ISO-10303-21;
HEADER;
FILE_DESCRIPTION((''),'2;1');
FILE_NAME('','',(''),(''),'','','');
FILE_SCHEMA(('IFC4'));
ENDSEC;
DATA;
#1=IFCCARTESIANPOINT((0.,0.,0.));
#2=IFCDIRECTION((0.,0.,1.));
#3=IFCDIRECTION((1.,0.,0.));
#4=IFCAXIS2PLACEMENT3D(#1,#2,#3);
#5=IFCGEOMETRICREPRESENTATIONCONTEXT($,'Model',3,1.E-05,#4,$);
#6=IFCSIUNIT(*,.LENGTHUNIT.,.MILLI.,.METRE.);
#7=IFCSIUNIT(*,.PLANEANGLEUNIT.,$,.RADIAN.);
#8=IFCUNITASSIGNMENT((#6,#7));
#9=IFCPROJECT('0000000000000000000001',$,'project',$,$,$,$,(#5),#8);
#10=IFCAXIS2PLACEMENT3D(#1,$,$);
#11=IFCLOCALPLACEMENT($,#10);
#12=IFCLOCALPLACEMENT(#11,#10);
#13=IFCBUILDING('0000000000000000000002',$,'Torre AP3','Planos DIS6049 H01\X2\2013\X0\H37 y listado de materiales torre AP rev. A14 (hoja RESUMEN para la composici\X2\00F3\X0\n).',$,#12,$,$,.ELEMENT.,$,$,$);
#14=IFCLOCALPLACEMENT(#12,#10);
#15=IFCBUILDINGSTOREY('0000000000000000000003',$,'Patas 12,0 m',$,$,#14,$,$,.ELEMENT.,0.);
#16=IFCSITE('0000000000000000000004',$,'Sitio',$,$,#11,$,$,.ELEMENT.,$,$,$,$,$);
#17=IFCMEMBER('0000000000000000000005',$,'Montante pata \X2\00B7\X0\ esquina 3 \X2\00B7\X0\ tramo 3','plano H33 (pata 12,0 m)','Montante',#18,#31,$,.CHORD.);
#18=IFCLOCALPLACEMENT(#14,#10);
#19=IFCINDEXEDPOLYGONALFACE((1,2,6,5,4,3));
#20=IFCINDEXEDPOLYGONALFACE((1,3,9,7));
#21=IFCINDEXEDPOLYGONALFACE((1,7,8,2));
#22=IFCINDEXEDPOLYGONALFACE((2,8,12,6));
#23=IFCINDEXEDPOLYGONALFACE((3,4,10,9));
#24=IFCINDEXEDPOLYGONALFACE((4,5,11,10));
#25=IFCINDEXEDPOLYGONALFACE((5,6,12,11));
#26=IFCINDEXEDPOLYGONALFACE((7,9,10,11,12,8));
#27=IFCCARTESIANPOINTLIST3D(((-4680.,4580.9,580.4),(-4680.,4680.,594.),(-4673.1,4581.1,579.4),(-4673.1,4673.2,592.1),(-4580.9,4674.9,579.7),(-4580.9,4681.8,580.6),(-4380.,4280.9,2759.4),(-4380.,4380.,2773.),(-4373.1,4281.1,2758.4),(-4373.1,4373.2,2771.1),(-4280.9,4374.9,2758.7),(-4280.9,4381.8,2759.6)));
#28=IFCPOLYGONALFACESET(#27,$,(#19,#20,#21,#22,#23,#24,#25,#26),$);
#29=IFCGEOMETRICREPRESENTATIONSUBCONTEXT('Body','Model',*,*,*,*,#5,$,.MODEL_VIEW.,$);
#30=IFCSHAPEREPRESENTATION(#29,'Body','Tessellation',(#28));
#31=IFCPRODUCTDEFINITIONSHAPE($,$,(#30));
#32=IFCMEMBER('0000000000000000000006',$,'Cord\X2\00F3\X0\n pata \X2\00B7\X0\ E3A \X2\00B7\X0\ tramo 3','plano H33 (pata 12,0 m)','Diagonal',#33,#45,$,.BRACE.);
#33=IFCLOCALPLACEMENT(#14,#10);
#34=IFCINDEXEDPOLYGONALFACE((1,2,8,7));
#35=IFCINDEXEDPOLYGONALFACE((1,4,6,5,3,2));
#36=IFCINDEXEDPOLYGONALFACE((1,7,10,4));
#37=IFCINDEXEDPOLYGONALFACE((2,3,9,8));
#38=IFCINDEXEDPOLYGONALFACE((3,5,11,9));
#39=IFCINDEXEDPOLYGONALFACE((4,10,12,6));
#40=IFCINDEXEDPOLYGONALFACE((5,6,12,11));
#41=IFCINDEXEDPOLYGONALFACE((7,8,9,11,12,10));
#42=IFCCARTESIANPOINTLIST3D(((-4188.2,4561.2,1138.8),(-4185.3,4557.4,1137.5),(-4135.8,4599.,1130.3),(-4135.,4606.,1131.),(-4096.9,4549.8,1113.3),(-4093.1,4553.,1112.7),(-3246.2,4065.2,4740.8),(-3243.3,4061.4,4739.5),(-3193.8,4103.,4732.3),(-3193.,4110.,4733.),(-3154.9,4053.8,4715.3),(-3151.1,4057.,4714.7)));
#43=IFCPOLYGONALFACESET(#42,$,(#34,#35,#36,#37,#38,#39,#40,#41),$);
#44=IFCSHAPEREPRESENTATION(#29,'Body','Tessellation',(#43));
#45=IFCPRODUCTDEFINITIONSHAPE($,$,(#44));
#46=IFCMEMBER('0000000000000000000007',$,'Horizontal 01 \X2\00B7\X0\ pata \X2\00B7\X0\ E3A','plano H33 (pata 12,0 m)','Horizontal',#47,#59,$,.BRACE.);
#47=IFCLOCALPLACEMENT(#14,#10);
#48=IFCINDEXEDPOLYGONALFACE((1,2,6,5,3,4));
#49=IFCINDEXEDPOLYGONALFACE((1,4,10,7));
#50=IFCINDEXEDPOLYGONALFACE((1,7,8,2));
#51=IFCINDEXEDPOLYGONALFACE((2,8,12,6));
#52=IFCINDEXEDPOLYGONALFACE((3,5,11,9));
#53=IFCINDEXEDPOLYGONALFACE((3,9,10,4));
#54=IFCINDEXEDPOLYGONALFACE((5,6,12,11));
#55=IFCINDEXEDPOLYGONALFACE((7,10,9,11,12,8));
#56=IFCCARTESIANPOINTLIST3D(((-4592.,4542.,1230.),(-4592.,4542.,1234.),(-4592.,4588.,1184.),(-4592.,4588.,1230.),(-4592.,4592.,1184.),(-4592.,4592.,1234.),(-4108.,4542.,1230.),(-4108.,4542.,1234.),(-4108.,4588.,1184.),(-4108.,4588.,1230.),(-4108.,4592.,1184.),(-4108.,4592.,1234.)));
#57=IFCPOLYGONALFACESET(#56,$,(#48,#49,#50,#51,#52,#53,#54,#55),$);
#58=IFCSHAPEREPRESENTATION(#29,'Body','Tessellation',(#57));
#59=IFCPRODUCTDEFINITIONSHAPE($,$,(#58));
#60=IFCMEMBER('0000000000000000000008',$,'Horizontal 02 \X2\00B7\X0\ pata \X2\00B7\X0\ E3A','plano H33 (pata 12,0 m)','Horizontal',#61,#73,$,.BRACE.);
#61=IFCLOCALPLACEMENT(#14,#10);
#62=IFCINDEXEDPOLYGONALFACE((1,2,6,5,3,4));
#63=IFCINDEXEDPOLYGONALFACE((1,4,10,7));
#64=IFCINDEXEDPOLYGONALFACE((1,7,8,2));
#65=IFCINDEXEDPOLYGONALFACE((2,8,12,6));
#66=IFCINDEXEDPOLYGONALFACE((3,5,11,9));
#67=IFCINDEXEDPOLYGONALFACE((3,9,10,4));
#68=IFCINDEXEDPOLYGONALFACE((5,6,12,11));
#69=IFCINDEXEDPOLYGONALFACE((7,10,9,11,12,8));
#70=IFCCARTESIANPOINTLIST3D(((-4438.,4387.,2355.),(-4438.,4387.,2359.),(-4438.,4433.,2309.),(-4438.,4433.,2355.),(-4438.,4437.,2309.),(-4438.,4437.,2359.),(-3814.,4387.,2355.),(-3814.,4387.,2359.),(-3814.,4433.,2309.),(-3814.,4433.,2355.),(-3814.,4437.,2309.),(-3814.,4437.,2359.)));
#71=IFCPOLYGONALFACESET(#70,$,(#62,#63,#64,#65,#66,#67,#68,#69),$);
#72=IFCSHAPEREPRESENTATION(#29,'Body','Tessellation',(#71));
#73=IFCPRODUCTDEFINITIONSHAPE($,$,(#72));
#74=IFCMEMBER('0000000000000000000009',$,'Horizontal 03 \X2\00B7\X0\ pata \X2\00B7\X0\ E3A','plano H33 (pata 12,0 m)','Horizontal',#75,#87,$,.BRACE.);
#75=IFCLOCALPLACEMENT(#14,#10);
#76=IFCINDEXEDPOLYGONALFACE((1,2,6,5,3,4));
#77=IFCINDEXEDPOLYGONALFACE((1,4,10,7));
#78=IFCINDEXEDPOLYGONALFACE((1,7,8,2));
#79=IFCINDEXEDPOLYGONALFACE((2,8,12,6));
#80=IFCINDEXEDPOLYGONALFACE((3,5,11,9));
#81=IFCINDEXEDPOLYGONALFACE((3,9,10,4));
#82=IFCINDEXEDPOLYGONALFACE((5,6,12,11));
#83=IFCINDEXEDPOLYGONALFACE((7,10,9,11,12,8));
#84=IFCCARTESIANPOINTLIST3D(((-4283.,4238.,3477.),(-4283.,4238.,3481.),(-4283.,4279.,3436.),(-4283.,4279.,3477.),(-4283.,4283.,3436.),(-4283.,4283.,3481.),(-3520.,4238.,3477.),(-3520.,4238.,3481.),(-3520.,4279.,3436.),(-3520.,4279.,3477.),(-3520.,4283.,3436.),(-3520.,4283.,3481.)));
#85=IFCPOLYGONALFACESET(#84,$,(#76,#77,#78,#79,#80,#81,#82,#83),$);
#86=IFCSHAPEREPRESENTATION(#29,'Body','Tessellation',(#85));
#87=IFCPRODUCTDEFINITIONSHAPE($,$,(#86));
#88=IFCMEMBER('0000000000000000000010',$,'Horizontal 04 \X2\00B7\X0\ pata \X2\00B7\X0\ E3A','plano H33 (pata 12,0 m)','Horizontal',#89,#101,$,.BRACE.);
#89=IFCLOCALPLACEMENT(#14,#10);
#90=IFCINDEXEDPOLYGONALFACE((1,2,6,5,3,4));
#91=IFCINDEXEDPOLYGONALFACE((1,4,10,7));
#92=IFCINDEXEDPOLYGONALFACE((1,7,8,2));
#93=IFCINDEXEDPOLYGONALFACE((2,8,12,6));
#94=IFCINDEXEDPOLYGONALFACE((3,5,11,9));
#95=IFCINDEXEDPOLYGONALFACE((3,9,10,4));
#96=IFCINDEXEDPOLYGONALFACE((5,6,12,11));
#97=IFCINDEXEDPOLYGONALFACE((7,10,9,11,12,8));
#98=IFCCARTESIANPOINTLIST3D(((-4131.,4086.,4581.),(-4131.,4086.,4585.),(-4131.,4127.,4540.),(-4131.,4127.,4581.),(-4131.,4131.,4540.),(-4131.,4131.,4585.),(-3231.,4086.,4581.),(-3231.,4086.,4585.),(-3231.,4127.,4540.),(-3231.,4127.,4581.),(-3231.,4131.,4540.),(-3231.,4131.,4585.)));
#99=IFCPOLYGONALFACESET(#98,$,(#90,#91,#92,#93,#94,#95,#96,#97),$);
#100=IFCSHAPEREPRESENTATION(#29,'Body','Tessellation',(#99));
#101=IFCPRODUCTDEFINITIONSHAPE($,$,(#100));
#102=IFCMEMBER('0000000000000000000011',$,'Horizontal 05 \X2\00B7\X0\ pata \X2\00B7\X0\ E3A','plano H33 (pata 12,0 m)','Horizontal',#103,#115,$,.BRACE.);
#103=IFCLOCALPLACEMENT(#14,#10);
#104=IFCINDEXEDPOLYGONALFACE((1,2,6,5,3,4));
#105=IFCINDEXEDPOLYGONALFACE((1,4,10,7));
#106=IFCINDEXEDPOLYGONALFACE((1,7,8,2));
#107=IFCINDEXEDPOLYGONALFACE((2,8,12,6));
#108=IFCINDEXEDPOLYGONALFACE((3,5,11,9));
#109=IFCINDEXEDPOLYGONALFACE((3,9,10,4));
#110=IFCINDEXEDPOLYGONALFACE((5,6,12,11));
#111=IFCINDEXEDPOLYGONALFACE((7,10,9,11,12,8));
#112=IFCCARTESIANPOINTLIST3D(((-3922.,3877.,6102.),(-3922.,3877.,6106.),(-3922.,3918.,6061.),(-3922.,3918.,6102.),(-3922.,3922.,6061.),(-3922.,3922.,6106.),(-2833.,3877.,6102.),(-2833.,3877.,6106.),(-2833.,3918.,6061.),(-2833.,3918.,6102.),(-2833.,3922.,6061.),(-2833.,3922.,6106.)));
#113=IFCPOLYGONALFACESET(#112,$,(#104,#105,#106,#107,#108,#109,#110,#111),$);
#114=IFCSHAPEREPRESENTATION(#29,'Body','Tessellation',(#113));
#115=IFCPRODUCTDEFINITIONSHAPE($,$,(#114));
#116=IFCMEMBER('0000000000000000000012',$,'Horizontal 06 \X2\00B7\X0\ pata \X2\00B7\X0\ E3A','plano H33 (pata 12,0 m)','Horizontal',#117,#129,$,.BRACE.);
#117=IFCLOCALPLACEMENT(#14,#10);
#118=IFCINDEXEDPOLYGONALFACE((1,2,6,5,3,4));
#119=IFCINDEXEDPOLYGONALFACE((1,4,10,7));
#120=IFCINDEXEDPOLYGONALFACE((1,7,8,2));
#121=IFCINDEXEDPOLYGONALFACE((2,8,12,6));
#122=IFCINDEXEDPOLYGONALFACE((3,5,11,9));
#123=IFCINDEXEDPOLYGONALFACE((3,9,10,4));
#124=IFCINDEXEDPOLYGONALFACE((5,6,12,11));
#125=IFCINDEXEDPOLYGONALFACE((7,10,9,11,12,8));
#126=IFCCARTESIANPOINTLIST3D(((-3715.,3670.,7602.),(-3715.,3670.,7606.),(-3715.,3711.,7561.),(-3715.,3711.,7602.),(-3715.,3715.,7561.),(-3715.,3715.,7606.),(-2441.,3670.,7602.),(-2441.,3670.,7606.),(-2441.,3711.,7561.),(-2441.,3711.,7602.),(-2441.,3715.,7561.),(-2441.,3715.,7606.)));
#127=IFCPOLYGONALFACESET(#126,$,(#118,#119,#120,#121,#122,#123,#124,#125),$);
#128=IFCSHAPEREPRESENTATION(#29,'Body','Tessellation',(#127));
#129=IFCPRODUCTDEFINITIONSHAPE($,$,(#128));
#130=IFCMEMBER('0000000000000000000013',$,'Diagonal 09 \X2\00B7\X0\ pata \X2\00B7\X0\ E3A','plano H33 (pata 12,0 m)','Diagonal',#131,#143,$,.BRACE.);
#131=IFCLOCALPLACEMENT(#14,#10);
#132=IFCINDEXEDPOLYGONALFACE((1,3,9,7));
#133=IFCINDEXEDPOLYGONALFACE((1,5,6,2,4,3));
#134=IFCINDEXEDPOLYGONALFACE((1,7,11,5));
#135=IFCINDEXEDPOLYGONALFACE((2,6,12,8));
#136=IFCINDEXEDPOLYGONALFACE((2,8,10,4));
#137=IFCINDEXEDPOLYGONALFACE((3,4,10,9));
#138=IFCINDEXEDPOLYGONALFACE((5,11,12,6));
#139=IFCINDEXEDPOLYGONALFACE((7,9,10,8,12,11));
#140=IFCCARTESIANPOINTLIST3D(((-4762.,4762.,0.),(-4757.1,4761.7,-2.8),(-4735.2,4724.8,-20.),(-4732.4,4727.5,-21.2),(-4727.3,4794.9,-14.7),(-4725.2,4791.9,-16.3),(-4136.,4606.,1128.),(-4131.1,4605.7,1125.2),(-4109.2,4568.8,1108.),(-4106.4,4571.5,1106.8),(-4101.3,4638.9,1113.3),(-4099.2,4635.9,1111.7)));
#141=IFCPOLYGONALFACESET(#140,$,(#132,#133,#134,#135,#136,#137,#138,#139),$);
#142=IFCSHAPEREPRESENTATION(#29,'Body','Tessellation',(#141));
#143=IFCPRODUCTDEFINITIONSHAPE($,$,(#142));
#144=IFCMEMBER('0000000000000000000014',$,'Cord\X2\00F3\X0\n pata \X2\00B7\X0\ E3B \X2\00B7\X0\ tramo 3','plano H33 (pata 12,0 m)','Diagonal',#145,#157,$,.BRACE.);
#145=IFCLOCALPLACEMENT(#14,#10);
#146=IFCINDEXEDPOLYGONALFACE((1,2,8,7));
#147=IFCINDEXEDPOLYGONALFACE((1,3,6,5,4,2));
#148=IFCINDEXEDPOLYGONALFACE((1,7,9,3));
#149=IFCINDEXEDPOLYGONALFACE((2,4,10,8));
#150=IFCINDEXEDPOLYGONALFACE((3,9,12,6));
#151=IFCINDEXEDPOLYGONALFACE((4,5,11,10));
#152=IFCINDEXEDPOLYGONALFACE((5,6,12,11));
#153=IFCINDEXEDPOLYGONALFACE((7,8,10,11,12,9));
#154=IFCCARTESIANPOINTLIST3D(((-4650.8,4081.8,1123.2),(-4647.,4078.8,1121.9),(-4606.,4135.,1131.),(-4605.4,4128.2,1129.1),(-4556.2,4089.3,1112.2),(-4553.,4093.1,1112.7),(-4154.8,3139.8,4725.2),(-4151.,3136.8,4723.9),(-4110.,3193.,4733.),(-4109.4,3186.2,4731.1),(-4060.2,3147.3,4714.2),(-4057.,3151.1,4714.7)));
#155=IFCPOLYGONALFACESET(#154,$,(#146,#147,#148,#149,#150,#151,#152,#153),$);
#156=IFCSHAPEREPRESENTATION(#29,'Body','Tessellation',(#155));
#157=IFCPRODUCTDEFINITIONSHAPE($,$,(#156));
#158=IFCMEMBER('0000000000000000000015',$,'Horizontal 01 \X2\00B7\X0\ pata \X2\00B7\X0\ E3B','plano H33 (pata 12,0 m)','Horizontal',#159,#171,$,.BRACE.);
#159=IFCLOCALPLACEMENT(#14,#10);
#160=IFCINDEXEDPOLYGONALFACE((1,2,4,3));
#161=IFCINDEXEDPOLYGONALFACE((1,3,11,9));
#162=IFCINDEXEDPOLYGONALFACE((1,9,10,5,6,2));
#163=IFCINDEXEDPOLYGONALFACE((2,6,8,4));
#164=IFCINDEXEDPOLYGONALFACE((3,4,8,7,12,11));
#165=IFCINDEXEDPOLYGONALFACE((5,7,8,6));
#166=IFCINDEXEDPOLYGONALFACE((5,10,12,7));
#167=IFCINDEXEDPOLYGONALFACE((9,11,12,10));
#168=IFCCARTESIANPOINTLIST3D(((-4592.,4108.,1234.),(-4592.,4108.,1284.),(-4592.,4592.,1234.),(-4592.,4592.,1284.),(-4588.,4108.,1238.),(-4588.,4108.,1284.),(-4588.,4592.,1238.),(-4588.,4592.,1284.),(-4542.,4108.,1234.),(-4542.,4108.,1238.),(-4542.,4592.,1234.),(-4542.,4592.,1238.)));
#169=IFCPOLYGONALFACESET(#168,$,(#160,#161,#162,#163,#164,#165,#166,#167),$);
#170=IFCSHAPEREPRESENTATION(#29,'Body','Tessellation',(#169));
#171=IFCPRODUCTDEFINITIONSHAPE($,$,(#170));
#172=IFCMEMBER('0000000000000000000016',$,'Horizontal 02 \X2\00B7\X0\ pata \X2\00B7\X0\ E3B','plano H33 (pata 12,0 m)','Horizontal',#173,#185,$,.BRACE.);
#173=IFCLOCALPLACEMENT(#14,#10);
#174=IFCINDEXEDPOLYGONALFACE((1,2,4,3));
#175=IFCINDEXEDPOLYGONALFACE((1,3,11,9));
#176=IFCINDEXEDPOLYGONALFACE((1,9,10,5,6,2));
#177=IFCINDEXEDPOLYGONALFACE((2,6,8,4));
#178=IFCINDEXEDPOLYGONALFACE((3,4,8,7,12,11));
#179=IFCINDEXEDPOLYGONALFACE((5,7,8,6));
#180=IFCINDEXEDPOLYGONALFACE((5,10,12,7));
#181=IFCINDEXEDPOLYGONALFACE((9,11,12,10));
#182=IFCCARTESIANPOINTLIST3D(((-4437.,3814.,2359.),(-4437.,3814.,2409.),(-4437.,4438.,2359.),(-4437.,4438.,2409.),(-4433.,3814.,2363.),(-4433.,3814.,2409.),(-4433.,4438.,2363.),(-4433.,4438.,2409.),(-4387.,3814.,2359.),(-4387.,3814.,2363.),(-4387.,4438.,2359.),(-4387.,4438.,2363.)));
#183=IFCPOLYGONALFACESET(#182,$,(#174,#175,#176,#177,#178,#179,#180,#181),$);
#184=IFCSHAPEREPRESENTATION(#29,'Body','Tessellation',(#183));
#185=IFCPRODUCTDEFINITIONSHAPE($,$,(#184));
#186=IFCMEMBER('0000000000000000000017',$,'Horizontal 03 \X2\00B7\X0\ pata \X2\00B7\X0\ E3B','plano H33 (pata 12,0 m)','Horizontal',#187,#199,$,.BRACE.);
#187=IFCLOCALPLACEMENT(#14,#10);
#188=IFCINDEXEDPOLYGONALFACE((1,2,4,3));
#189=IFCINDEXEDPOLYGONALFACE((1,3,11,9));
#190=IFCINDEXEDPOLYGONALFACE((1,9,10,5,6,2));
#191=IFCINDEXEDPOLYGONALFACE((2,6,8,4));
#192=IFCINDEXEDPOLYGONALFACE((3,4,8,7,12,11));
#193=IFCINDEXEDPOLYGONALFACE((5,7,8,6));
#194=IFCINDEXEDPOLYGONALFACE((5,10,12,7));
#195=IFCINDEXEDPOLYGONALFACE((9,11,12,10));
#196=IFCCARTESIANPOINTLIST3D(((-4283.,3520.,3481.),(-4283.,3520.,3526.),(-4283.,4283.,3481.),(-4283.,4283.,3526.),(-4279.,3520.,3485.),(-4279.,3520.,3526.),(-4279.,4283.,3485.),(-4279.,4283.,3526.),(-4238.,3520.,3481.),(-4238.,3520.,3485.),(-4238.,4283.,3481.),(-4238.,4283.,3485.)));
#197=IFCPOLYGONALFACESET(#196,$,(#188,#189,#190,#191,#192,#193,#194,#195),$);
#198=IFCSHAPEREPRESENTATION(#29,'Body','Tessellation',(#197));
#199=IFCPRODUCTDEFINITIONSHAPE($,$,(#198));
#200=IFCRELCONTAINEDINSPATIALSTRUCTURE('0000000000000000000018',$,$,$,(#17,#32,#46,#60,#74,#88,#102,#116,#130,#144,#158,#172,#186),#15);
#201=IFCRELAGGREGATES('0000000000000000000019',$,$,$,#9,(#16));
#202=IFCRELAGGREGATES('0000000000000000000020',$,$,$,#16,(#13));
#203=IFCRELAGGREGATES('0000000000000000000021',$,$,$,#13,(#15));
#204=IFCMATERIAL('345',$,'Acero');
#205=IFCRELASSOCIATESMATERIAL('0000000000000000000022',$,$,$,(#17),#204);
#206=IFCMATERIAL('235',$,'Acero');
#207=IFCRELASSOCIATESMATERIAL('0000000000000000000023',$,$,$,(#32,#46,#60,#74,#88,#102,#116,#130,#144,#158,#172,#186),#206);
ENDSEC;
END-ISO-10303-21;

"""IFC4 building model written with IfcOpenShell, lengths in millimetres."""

from ifc_helpers import new_model, si_unit, frame, frame_2d, origin, origin_with_axes, place, context, subcontext, project, spatial, l_section, extrude, material, element, save


model = new_model("IFC4")

# Units and contexts
model_context = context("Model", 3, precision=1e-05, world=origin_with_axes())
body_context = subcontext(model_context, "Body", "Model", "MODEL_VIEW")
ifc_project = project(units=[si_unit("LENGTHUNIT", "METRE", prefix="MILLI"), si_unit("PLANEANGLEUNIT", "RADIAN")], contexts=[model_context])

# Site, building, storey
site_placement = place(None, origin())
site = spatial("IfcSite", under=ifc_project, at=site_placement, Name="Sitio", CompositionType="ELEMENT")
building_placement = place(site_placement, origin())
building = spatial("IfcBuilding", under=site, at=building_placement, Name="Torre AP3", Description="Planos DIS6049 H01–H37 y listado de materiales torre AP rev. A14 (hoja RESUMEN para la composición).", CompositionType="ELEMENT")
storey_placement = place(building_placement, origin())
storey = spatial("IfcBuildingStorey", under=building, at=storey_placement, Name="Patas 12,0 m", CompositionType="ELEMENT", Elevation=0.0)

# Members
ifc_material_1 = material(Name="345", Category="Acero")
member_1_placement = place(storey_placement, frame((-4380.0, 4380.0, 2773.0), z_axis=(-0.13514, 0.13514, -0.981567), x_axis=(0.990827, 0.018432, -0.133877)))
element("IfcMember", 1, at=member_1_placement, inside=storey, material=ifc_material_1, Name="Montante pata · esquina 3 · tramo 3", Description="plano H33 (pata 12,0 m)", ObjectType="Montante", PredefinedType="CHORD", context=body_context, shape_type="SweptSolid", body=[
    extrude(l_section(Depth=100.0, Width=100.0, Thickness=7.0, at=frame_2d((50.0, 50.0))), None, (0.0, 0.0, 1.0), 2219.9),
])
ifc_material_2 = material(Name="235", Category="Acero")
member_2_placement = place(storey_placement, frame((-3193.0, 4110.0, 4733.0), z_axis=(-0.250797, 0.132054, -0.958991), x_axis=(0.598693, -0.757312, -0.260854)))
element("IfcMember", 2, at=member_2_placement, inside=storey, material=ifc_material_2, Name="Cordón pata · E3A · tramo 3", Description="plano H33 (pata 12,0 m)", ObjectType="Diagonal", PredefinedType="BRACE", context=body_context, shape_type="SweptSolid", body=[
    extrude(l_section(Depth=70.0, Width=70.0, Thickness=5.0, at=frame_2d((35.0, 35.0))), None, (0.0, 0.0, 1.0), 3756.0),
])
member_3_placement = place(storey_placement, frame((-4592.0, 4592.0, 1234.0), z_axis=(1.0, 0.0, 0.0), x_axis=(0.0, -1.0, 0.0)))
element("IfcMember", 3, at=member_3_placement, inside=storey, material=ifc_material_2, Name="Horizontal 01 · pata · E3A", Description="plano H33 (pata 12,0 m)", ObjectType="Horizontal", PredefinedType="BRACE", context=body_context, shape_type="SweptSolid", body=[
    extrude(l_section(Depth=50.0, Width=50.0, Thickness=4.0, at=frame_2d((25.0, 25.0))), None, (0.0, 0.0, 1.0), 484.0),
])
member_4_placement = place(storey_placement, frame((-4438.0, 4437.0, 2359.0), z_axis=(1.0, 0.0, 0.0), x_axis=(0.0, -1.0, 0.0)))
element("IfcMember", 4, at=member_4_placement, inside=storey, material=ifc_material_2, Name="Horizontal 02 · pata · E3A", Description="plano H33 (pata 12,0 m)", ObjectType="Horizontal", PredefinedType="BRACE", context=body_context, shape_type="SweptSolid", body=[
    extrude(l_section(Depth=50.0, Width=50.0, Thickness=4.0, at=frame_2d((25.0, 25.0))), None, (0.0, 0.0, 1.0), 624.0),
])
member_5_placement = place(storey_placement, frame((-4283.0, 4283.0, 3481.0), z_axis=(1.0, 0.0, 0.0), x_axis=(0.0, -1.0, 0.0)))
element("IfcMember", 5, at=member_5_placement, inside=storey, material=ifc_material_2, Name="Horizontal 03 · pata · E3A", Description="plano H33 (pata 12,0 m)", ObjectType="Horizontal", PredefinedType="BRACE", context=body_context, shape_type="SweptSolid", body=[
    extrude(l_section(Depth=45.0, Width=45.0, Thickness=4.0, at=frame_2d((22.5, 22.5))), None, (0.0, 0.0, 1.0), 763.0),
])
member_6_placement = place(storey_placement, frame((-4131.0, 4131.0, 4585.0), z_axis=(1.0, 0.0, 0.0), x_axis=(0.0, -1.0, 0.0)))
element("IfcMember", 6, at=member_6_placement, inside=storey, material=ifc_material_2, Name="Horizontal 04 · pata · E3A", Description="plano H33 (pata 12,0 m)", ObjectType="Horizontal", PredefinedType="BRACE", context=body_context, shape_type="SweptSolid", body=[
    extrude(l_section(Depth=45.0, Width=45.0, Thickness=4.0, at=frame_2d((22.5, 22.5))), None, (0.0, 0.0, 1.0), 900.0),
])
member_7_placement = place(storey_placement, frame((-3922.0, 3922.0, 6106.0), z_axis=(1.0, 0.0, 0.0), x_axis=(0.0, -1.0, 0.0)))
element("IfcMember", 7, at=member_7_placement, inside=storey, material=ifc_material_2, Name="Horizontal 05 · pata · E3A", Description="plano H33 (pata 12,0 m)", ObjectType="Horizontal", PredefinedType="BRACE", context=body_context, shape_type="SweptSolid", body=[
    extrude(l_section(Depth=45.0, Width=45.0, Thickness=4.0, at=frame_2d((22.5, 22.5))), None, (0.0, 0.0, 1.0), 1089.0),
])
member_8_placement = place(storey_placement, frame((-3715.0, 3715.0, 7606.0), z_axis=(1.0, 0.0, 0.0), x_axis=(0.0, -1.0, 0.0)))
element("IfcMember", 8, at=member_8_placement, inside=storey, material=ifc_material_2, Name="Horizontal 06 · pata · E3A", Description="plano H33 (pata 12,0 m)", ObjectType="Horizontal", PredefinedType="BRACE", context=body_context, shape_type="SweptSolid", body=[
    extrude(l_section(Depth=45.0, Width=45.0, Thickness=4.0, at=frame_2d((22.5, 22.5))), None, (0.0, 0.0, 1.0), 1274.0),
])
member_9_placement = place(storey_placement, frame((-4762.0, 4762.0, 0.0), z_axis=(0.481739, -0.12005, 0.868053), x_axis=(0.53622, -0.743093, -0.400351)))
element("IfcMember", 9, at=member_9_placement, inside=storey, material=ifc_material_2, Name="Diagonal 09 · pata · E3A", Description="plano H33 (pata 12,0 m)", ObjectType="Diagonal", PredefinedType="BRACE", context=body_context, shape_type="SweptSolid", body=[
    extrude(l_section(Depth=50.0, Width=50.0, Thickness=4.0, at=frame_2d((25.0, 25.0))), None, (0.0, 0.0, 1.0), 1299.5),
])
member_10_placement = place(storey_placement, frame((-4110.0, 3193.0, 4733.0), z_axis=(-0.132054, 0.250797, -0.958991), x_axis=(0.757312, -0.598693, -0.260854)))
element("IfcMember", 10, at=member_10_placement, inside=storey, material=ifc_material_2, Name="Cordón pata · E3B · tramo 3", Description="plano H33 (pata 12,0 m)", ObjectType="Diagonal", PredefinedType="BRACE", context=body_context, shape_type="SweptSolid", body=[
    extrude(l_section(Depth=70.0, Width=70.0, Thickness=5.0, at=frame_2d((35.0, 35.0))), None, (0.0, 0.0, 1.0), 3756.0),
])
member_11_placement = place(storey_placement, frame((-4592.0, 4592.0, 1234.0), z_axis=(0.0, -1.0, 0.0), x_axis=(1.0, 0.0, 0.0)))
element("IfcMember", 11, at=member_11_placement, inside=storey, material=ifc_material_2, Name="Horizontal 01 · pata · E3B", Description="plano H33 (pata 12,0 m)", ObjectType="Horizontal", PredefinedType="BRACE", context=body_context, shape_type="SweptSolid", body=[
    extrude(l_section(Depth=50.0, Width=50.0, Thickness=4.0, at=frame_2d((25.0, 25.0))), None, (0.0, 0.0, 1.0), 484.0),
])
member_12_placement = place(storey_placement, frame((-4437.0, 4438.0, 2359.0), z_axis=(0.0, -1.0, 0.0), x_axis=(1.0, 0.0, 0.0)))
element("IfcMember", 12, at=member_12_placement, inside=storey, material=ifc_material_2, Name="Horizontal 02 · pata · E3B", Description="plano H33 (pata 12,0 m)", ObjectType="Horizontal", PredefinedType="BRACE", context=body_context, shape_type="SweptSolid", body=[
    extrude(l_section(Depth=50.0, Width=50.0, Thickness=4.0, at=frame_2d((25.0, 25.0))), None, (0.0, 0.0, 1.0), 624.0),
])
member_13_placement = place(storey_placement, frame((-4283.0, 4283.0, 3481.0), z_axis=(0.0, -1.0, 0.0), x_axis=(1.0, 0.0, 0.0)))
element("IfcMember", 13, at=member_13_placement, inside=storey, material=ifc_material_2, Name="Horizontal 03 · pata · E3B", Description="plano H33 (pata 12,0 m)", ObjectType="Horizontal", PredefinedType="BRACE", context=body_context, shape_type="SweptSolid", body=[
    extrude(l_section(Depth=45.0, Width=45.0, Thickness=4.0, at=frame_2d((22.5, 22.5))), None, (0.0, 0.0, 1.0), 763.0),
])

save(model, "model.ifc")
